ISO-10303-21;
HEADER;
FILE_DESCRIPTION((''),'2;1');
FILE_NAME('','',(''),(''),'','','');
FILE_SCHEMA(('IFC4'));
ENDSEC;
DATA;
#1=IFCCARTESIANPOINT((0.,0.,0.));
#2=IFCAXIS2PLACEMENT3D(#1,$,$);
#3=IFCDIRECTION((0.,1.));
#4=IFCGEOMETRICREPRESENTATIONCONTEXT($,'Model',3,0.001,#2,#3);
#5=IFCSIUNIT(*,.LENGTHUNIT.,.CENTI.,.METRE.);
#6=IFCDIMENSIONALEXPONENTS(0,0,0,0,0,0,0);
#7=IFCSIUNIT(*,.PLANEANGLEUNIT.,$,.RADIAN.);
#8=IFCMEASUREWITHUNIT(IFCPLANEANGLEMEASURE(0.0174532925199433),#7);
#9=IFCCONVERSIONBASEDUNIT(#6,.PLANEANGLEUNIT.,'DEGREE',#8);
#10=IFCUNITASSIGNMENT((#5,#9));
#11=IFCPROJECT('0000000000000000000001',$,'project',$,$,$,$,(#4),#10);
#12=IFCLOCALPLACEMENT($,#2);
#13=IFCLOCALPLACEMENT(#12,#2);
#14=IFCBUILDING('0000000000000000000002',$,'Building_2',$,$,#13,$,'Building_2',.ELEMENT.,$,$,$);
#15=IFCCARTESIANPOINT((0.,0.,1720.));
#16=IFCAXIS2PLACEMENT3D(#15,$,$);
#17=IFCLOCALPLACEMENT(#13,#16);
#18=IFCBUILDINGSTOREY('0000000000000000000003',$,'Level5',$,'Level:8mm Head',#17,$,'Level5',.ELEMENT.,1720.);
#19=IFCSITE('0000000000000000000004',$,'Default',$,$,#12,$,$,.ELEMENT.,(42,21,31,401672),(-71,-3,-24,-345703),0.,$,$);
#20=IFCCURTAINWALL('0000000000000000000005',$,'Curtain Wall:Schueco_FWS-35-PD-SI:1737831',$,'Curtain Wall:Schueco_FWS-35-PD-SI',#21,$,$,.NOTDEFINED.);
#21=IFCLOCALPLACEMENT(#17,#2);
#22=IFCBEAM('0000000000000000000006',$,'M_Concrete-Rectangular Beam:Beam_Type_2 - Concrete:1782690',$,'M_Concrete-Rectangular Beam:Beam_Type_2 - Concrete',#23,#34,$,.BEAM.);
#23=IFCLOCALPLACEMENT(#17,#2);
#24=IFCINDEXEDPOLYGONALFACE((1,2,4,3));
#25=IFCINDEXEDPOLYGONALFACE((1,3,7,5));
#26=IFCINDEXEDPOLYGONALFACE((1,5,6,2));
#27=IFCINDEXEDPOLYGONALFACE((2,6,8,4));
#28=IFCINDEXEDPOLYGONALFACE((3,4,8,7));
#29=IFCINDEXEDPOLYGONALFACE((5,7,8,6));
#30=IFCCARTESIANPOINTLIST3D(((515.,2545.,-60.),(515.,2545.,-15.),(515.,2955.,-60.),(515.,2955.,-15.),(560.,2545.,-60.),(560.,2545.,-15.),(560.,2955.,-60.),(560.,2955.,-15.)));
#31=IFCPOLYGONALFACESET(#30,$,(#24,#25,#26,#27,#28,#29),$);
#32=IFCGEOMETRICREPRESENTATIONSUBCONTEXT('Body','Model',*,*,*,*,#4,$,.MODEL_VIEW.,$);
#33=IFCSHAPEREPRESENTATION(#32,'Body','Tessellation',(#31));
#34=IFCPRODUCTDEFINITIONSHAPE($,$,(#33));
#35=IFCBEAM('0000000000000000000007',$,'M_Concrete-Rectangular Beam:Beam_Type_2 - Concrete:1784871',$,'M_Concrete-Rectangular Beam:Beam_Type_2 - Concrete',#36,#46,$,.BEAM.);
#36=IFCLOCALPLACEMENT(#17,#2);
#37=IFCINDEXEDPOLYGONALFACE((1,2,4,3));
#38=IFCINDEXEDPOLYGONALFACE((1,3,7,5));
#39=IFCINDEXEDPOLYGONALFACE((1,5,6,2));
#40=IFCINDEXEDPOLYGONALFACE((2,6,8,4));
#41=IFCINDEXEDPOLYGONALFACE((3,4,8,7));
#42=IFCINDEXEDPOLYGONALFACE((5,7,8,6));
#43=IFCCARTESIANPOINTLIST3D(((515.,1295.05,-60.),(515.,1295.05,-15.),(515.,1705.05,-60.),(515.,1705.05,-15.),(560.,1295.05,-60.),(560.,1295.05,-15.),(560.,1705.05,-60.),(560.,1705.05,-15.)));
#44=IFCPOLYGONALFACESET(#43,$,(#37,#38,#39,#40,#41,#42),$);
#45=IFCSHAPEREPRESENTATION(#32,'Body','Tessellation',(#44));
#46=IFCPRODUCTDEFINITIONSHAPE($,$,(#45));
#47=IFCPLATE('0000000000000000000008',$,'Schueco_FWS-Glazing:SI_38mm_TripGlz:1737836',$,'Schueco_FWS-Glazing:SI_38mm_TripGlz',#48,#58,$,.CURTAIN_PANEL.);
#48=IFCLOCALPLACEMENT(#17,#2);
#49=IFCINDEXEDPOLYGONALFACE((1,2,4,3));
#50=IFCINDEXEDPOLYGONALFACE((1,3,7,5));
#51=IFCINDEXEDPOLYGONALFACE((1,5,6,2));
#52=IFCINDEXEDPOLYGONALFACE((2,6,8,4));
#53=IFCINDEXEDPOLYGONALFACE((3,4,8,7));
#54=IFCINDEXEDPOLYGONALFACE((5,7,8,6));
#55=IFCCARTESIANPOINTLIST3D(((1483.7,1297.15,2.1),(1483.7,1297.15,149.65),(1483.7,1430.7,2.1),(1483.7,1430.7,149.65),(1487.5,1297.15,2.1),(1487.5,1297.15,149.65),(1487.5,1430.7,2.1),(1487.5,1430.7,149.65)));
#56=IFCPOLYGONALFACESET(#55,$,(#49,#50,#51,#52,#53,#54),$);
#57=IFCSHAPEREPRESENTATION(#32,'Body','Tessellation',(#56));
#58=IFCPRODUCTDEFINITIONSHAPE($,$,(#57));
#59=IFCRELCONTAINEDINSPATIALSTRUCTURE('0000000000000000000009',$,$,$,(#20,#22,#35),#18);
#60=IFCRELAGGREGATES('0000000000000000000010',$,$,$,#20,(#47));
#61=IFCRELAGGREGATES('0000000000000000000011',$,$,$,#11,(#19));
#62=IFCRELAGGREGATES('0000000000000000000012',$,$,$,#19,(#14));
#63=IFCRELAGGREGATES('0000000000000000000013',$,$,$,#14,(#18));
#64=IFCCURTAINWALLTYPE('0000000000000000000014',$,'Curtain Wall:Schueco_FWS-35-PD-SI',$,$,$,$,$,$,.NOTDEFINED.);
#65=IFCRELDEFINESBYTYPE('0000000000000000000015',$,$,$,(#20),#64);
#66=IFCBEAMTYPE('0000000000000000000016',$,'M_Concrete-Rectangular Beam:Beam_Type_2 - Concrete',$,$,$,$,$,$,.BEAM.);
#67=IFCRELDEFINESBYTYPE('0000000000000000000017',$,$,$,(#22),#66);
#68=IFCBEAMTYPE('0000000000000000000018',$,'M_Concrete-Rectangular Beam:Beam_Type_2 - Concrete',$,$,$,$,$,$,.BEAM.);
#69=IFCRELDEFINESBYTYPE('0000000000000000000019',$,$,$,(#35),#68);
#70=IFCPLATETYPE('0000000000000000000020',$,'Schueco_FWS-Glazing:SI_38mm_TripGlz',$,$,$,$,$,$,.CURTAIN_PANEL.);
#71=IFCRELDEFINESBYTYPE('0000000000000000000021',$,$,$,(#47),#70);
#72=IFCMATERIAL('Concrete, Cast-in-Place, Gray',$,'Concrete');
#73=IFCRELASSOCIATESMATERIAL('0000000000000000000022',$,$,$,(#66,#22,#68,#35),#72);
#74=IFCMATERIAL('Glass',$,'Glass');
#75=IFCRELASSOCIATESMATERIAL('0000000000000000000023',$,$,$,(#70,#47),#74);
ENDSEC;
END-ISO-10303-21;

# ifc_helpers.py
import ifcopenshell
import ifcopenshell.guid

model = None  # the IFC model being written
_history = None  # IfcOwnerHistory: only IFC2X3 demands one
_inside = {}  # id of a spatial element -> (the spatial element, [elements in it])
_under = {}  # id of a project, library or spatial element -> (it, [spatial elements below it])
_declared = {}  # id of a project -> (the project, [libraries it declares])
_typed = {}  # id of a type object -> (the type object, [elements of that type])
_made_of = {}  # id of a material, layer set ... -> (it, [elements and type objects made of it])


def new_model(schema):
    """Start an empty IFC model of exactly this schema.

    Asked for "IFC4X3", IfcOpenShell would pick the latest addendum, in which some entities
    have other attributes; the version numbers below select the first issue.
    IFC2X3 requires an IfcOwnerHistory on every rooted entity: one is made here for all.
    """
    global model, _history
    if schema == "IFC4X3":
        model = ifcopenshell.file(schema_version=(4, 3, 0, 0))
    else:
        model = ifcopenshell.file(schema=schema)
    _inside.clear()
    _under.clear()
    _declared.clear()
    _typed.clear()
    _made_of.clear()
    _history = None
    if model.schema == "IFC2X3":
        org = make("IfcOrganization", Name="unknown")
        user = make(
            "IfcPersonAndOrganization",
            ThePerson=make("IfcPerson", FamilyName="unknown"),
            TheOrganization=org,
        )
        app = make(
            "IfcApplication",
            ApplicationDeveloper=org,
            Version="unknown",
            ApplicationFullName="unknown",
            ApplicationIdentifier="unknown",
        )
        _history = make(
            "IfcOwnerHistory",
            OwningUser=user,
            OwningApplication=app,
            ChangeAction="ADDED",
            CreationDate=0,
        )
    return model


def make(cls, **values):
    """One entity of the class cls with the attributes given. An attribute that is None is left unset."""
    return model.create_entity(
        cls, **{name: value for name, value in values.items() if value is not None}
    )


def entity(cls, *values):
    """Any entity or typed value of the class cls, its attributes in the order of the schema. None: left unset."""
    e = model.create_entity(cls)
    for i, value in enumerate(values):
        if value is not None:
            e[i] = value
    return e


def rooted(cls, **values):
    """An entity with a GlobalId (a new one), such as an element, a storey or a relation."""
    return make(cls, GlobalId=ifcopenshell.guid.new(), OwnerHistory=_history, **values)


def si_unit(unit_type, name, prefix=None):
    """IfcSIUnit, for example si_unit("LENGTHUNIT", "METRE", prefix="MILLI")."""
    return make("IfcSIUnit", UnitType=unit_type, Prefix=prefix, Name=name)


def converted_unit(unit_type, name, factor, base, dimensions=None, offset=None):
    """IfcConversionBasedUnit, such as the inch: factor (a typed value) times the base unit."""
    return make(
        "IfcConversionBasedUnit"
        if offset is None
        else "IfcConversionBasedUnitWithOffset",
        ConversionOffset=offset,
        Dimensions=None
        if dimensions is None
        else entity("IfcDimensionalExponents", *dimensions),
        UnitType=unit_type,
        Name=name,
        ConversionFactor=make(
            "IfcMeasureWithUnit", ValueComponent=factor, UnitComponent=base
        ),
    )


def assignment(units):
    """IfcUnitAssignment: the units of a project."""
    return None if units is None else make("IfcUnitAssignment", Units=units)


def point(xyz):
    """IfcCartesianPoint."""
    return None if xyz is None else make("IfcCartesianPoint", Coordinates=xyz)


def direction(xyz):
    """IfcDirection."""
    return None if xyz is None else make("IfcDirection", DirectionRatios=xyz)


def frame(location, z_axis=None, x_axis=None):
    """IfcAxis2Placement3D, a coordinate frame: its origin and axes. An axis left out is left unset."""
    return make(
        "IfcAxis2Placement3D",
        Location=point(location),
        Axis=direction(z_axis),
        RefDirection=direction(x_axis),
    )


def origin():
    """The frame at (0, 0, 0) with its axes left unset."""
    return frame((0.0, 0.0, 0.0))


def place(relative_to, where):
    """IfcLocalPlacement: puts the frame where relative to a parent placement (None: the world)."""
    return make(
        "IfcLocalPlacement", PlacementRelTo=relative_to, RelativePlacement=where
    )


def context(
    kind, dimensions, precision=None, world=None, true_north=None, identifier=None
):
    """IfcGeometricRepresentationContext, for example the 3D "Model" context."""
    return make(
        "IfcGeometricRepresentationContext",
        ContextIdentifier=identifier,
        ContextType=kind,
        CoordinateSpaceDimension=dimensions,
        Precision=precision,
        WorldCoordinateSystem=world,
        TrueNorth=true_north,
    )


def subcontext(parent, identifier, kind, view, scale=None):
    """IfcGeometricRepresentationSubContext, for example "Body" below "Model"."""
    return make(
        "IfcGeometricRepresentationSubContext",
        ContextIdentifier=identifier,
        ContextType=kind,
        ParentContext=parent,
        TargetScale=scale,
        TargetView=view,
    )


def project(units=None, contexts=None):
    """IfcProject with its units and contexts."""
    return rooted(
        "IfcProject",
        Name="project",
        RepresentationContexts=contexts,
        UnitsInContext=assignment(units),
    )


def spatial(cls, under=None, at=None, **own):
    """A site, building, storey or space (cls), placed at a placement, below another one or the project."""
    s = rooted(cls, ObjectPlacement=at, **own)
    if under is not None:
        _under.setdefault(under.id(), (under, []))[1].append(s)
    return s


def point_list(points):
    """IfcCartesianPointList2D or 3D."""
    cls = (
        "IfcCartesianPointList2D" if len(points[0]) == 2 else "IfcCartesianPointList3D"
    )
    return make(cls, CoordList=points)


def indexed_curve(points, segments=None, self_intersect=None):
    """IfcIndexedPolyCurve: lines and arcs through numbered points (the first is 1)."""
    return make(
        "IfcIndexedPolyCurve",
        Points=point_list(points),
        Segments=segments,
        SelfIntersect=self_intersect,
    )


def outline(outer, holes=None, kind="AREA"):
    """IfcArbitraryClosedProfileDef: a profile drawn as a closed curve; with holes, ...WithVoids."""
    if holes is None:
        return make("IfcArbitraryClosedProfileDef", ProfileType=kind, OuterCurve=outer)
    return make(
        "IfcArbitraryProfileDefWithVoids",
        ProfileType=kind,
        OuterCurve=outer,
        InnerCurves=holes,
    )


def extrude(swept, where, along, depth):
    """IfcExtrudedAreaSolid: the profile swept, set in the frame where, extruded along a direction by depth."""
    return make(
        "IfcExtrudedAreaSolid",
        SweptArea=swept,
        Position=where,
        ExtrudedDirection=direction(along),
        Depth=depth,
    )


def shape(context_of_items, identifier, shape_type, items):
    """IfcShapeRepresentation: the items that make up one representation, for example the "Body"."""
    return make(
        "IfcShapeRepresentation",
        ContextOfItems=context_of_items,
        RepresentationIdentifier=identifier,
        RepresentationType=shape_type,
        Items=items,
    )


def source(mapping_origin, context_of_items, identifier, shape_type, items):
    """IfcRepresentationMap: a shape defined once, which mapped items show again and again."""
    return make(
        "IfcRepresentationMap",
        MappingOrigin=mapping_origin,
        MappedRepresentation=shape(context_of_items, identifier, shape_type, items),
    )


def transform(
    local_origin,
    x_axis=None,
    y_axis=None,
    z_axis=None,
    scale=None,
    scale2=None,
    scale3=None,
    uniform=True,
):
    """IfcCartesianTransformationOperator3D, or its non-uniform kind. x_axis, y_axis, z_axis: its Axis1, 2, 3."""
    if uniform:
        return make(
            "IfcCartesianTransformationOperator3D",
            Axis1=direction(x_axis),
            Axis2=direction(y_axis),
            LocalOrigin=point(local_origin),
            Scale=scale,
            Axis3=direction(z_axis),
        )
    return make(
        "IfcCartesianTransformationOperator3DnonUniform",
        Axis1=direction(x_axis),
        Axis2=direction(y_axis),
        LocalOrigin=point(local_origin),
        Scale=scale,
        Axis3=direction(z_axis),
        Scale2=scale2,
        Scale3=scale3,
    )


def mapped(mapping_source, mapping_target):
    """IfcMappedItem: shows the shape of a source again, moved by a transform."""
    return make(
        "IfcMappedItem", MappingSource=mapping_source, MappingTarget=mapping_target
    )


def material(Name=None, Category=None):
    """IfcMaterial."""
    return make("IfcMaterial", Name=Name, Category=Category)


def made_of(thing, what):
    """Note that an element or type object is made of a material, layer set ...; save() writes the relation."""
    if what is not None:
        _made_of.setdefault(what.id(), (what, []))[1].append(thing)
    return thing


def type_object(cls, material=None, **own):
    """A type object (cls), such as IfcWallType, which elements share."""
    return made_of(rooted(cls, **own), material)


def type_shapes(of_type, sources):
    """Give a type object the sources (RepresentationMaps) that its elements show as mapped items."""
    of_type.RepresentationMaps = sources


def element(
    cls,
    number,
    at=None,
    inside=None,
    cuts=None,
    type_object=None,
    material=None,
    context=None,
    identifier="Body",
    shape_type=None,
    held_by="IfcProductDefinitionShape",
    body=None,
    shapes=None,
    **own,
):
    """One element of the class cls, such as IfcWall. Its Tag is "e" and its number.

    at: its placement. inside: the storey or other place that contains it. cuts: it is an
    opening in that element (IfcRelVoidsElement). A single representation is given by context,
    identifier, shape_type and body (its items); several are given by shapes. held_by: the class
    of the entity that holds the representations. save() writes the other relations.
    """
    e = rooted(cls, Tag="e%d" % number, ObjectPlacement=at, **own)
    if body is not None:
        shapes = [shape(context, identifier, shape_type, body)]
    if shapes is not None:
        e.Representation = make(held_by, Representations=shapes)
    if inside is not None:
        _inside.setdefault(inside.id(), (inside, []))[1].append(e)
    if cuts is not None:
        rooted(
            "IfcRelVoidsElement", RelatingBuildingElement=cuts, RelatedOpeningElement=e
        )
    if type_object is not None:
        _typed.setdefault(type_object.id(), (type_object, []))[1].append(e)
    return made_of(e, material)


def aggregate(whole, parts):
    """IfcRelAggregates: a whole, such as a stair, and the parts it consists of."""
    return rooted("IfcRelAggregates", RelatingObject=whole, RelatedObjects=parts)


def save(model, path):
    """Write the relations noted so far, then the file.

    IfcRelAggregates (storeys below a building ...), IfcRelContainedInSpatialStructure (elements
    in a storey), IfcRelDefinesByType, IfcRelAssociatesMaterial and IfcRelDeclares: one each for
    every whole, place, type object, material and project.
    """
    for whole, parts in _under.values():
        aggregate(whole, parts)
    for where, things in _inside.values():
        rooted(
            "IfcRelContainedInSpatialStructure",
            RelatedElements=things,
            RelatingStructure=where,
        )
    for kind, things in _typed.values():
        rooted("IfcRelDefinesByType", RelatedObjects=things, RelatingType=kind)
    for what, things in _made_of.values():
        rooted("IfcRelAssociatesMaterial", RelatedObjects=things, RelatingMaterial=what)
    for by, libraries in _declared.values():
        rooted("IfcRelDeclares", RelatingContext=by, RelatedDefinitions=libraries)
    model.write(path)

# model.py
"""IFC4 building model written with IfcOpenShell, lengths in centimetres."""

from ifc_helpers import new_model, entity, si_unit, converted_unit, direction, frame, origin, place, context, subcontext, project, spatial, indexed_curve, outline, extrude, source, transform, mapped, material, type_object, type_shapes, element, aggregate, save


model = new_model("IFC4")

# Units and contexts
model_context = context("Model", 3, precision=0.001, world=origin(), true_north=direction((0.0, 1.0)))
body_context = subcontext(model_context, "Body", "Model", "MODEL_VIEW")
ifc_project = project(units=[si_unit("LENGTHUNIT", "METRE", prefix="CENTI"), converted_unit("PLANEANGLEUNIT", "DEGREE", entity("IfcPlaneAngleMeasure", 0.0174532925199433), si_unit("PLANEANGLEUNIT", "RADIAN"), dimensions=[0, 0, 0, 0, 0, 0, 0])], contexts=[model_context])

# Site, building, storey
site_placement = place(None, origin())
site = spatial("IfcSite", under=ifc_project, at=site_placement, Name="Default", CompositionType="ELEMENT", RefLatitude=(42, 21, 31, 401672), RefLongitude=(-71, -3, -24, -345703), RefElevation=0.0)
building_placement = place(site_placement, origin())
building = spatial("IfcBuilding", under=site, at=building_placement, Name="Building_2", LongName="Building_2", CompositionType="ELEMENT")
storey_placement = place(building_placement, frame((0.0, 0.0, 1720.0)))
storey = spatial("IfcBuildingStorey", under=building, at=storey_placement, Name="Level5", ObjectType="Level:8mm Head", LongName="Level5", CompositionType="ELEMENT", Elevation=1720.0)

# Curtain wall
curtain_wall_type = type_object("IfcCurtainWallType", Name="Curtain Wall:Schueco_FWS-35-PD-SI", PredefinedType="NOTDEFINED")
curtain_wall_placement = place(storey_placement, frame((0.0, 0.0, -1720.0)))
curtain_wall = element("IfcCurtainWall", 1, at=curtain_wall_placement, inside=storey, type_object=curtain_wall_type, Name="Curtain Wall:Schueco_FWS-35-PD-SI:1737831", ObjectType="Curtain Wall:Schueco_FWS-35-PD-SI", PredefinedType="NOTDEFINED")

# Beams
ifc_material_1 = material(Name="Concrete, Cast-in-Place, Gray", Category="Concrete")
beam_type_1 = type_object("IfcBeamType", Name="M_Concrete-Rectangular Beam:Beam_Type_2 - Concrete", PredefinedType="BEAM", material=ifc_material_1)
shared_shape_1 = source(origin(), body_context, "Body", "SweptSolid", [
    extrude(outline(indexed_curve([(-22.5, -22.5), (22.5, -22.5), (22.5, 22.5), (-22.5, 22.5), (-22.5, -22.5)], self_intersect=False)), frame((537.5, 2955.0, 1682.5), z_axis=(0.0, -1.0, 0.0), x_axis=(-1.0, 0.0, 0.0)), (0.0, 0.0, 1.0), 410.0),
])
type_shapes(beam_type_1, [shared_shape_1])
beam_1_placement = place(storey_placement, frame((0.0, 0.0, -1720.0)))
element("IfcBeam", 2, at=beam_1_placement, inside=storey, type_object=beam_type_1, material=ifc_material_1, Name="M_Concrete-Rectangular Beam:Beam_Type_2 - Concrete:1782690", ObjectType="M_Concrete-Rectangular Beam:Beam_Type_2 - Concrete", PredefinedType="BEAM", context=body_context, shape_type="MappedRepresentation", body=[
    mapped(shared_shape_1, transform((0.0, 0.0, 0.0), scale=1.0)),
])
beam_type_2 = type_object("IfcBeamType", Name="M_Concrete-Rectangular Beam:Beam_Type_2 - Concrete", PredefinedType="BEAM", material=ifc_material_1)
shared_shape_2 = source(origin(), body_context, "Body", "SweptSolid", [
    extrude(outline(indexed_curve([(-22.5, -22.5), (22.5, -22.5), (22.5, 22.5), (-22.5, 22.5), (-22.5, -22.5)], self_intersect=False)), frame((537.5, 1705.05, 1682.5), z_axis=(0.0, -1.0, 0.0), x_axis=(-1.0, 0.0, 0.0)), (0.0, 0.0, 1.0), 410.0),
])
type_shapes(beam_type_2, [shared_shape_2])
beam_2_placement = place(storey_placement, frame((0.0, 0.0, -1720.0)))
element("IfcBeam", 3, at=beam_2_placement, inside=storey, type_object=beam_type_2, material=ifc_material_1, Name="M_Concrete-Rectangular Beam:Beam_Type_2 - Concrete:1784871", ObjectType="M_Concrete-Rectangular Beam:Beam_Type_2 - Concrete", PredefinedType="BEAM", context=body_context, shape_type="MappedRepresentation", body=[
    mapped(shared_shape_2, transform((0.0, 0.0, 0.0), scale=1.0)),
])

# Plate
ifc_material_2 = material(Name="Glass", Category="Glass")
plate_type = type_object("IfcPlateType", Name="Schueco_FWS-Glazing:SI_38mm_TripGlz", PredefinedType="CURTAIN_PANEL", material=ifc_material_2)
shared_shape_3 = source(origin(), body_context, "Body", "SweptSolid", [
    extrude(outline(indexed_curve([(-1.9, -66.78), (1.9, -66.78), (1.9, 66.78), (-1.9, 66.78), (-1.9, -66.78)], self_intersect=False)), frame((0.0, -1.9, 0.0), z_axis=(0.0, 0.0, 1.0), x_axis=(0.0, 1.0, 0.0)), (0.0, 0.0, 1.0), 147.55),
])
type_shapes(plate_type, [shared_shape_3])
plate_placement = place(curtain_wall_placement, frame((1487.5, 1363.92, 1722.1), z_axis=(0.0, 0.0, 1.0), x_axis=(0.0, -1.0, 0.0)))
plate = element("IfcPlate", 4, at=plate_placement, type_object=plate_type, material=ifc_material_2, Name="Schueco_FWS-Glazing:SI_38mm_TripGlz:1737836", ObjectType="Schueco_FWS-Glazing:SI_38mm_TripGlz", PredefinedType="CURTAIN_PANEL", context=body_context, shape_type="MappedRepresentation", body=[
    mapped(shared_shape_3, transform((0.0, 0.0, 0.0), scale=1.0)),
])
aggregate(curtain_wall, [plate])

save(model, "model.ifc")
